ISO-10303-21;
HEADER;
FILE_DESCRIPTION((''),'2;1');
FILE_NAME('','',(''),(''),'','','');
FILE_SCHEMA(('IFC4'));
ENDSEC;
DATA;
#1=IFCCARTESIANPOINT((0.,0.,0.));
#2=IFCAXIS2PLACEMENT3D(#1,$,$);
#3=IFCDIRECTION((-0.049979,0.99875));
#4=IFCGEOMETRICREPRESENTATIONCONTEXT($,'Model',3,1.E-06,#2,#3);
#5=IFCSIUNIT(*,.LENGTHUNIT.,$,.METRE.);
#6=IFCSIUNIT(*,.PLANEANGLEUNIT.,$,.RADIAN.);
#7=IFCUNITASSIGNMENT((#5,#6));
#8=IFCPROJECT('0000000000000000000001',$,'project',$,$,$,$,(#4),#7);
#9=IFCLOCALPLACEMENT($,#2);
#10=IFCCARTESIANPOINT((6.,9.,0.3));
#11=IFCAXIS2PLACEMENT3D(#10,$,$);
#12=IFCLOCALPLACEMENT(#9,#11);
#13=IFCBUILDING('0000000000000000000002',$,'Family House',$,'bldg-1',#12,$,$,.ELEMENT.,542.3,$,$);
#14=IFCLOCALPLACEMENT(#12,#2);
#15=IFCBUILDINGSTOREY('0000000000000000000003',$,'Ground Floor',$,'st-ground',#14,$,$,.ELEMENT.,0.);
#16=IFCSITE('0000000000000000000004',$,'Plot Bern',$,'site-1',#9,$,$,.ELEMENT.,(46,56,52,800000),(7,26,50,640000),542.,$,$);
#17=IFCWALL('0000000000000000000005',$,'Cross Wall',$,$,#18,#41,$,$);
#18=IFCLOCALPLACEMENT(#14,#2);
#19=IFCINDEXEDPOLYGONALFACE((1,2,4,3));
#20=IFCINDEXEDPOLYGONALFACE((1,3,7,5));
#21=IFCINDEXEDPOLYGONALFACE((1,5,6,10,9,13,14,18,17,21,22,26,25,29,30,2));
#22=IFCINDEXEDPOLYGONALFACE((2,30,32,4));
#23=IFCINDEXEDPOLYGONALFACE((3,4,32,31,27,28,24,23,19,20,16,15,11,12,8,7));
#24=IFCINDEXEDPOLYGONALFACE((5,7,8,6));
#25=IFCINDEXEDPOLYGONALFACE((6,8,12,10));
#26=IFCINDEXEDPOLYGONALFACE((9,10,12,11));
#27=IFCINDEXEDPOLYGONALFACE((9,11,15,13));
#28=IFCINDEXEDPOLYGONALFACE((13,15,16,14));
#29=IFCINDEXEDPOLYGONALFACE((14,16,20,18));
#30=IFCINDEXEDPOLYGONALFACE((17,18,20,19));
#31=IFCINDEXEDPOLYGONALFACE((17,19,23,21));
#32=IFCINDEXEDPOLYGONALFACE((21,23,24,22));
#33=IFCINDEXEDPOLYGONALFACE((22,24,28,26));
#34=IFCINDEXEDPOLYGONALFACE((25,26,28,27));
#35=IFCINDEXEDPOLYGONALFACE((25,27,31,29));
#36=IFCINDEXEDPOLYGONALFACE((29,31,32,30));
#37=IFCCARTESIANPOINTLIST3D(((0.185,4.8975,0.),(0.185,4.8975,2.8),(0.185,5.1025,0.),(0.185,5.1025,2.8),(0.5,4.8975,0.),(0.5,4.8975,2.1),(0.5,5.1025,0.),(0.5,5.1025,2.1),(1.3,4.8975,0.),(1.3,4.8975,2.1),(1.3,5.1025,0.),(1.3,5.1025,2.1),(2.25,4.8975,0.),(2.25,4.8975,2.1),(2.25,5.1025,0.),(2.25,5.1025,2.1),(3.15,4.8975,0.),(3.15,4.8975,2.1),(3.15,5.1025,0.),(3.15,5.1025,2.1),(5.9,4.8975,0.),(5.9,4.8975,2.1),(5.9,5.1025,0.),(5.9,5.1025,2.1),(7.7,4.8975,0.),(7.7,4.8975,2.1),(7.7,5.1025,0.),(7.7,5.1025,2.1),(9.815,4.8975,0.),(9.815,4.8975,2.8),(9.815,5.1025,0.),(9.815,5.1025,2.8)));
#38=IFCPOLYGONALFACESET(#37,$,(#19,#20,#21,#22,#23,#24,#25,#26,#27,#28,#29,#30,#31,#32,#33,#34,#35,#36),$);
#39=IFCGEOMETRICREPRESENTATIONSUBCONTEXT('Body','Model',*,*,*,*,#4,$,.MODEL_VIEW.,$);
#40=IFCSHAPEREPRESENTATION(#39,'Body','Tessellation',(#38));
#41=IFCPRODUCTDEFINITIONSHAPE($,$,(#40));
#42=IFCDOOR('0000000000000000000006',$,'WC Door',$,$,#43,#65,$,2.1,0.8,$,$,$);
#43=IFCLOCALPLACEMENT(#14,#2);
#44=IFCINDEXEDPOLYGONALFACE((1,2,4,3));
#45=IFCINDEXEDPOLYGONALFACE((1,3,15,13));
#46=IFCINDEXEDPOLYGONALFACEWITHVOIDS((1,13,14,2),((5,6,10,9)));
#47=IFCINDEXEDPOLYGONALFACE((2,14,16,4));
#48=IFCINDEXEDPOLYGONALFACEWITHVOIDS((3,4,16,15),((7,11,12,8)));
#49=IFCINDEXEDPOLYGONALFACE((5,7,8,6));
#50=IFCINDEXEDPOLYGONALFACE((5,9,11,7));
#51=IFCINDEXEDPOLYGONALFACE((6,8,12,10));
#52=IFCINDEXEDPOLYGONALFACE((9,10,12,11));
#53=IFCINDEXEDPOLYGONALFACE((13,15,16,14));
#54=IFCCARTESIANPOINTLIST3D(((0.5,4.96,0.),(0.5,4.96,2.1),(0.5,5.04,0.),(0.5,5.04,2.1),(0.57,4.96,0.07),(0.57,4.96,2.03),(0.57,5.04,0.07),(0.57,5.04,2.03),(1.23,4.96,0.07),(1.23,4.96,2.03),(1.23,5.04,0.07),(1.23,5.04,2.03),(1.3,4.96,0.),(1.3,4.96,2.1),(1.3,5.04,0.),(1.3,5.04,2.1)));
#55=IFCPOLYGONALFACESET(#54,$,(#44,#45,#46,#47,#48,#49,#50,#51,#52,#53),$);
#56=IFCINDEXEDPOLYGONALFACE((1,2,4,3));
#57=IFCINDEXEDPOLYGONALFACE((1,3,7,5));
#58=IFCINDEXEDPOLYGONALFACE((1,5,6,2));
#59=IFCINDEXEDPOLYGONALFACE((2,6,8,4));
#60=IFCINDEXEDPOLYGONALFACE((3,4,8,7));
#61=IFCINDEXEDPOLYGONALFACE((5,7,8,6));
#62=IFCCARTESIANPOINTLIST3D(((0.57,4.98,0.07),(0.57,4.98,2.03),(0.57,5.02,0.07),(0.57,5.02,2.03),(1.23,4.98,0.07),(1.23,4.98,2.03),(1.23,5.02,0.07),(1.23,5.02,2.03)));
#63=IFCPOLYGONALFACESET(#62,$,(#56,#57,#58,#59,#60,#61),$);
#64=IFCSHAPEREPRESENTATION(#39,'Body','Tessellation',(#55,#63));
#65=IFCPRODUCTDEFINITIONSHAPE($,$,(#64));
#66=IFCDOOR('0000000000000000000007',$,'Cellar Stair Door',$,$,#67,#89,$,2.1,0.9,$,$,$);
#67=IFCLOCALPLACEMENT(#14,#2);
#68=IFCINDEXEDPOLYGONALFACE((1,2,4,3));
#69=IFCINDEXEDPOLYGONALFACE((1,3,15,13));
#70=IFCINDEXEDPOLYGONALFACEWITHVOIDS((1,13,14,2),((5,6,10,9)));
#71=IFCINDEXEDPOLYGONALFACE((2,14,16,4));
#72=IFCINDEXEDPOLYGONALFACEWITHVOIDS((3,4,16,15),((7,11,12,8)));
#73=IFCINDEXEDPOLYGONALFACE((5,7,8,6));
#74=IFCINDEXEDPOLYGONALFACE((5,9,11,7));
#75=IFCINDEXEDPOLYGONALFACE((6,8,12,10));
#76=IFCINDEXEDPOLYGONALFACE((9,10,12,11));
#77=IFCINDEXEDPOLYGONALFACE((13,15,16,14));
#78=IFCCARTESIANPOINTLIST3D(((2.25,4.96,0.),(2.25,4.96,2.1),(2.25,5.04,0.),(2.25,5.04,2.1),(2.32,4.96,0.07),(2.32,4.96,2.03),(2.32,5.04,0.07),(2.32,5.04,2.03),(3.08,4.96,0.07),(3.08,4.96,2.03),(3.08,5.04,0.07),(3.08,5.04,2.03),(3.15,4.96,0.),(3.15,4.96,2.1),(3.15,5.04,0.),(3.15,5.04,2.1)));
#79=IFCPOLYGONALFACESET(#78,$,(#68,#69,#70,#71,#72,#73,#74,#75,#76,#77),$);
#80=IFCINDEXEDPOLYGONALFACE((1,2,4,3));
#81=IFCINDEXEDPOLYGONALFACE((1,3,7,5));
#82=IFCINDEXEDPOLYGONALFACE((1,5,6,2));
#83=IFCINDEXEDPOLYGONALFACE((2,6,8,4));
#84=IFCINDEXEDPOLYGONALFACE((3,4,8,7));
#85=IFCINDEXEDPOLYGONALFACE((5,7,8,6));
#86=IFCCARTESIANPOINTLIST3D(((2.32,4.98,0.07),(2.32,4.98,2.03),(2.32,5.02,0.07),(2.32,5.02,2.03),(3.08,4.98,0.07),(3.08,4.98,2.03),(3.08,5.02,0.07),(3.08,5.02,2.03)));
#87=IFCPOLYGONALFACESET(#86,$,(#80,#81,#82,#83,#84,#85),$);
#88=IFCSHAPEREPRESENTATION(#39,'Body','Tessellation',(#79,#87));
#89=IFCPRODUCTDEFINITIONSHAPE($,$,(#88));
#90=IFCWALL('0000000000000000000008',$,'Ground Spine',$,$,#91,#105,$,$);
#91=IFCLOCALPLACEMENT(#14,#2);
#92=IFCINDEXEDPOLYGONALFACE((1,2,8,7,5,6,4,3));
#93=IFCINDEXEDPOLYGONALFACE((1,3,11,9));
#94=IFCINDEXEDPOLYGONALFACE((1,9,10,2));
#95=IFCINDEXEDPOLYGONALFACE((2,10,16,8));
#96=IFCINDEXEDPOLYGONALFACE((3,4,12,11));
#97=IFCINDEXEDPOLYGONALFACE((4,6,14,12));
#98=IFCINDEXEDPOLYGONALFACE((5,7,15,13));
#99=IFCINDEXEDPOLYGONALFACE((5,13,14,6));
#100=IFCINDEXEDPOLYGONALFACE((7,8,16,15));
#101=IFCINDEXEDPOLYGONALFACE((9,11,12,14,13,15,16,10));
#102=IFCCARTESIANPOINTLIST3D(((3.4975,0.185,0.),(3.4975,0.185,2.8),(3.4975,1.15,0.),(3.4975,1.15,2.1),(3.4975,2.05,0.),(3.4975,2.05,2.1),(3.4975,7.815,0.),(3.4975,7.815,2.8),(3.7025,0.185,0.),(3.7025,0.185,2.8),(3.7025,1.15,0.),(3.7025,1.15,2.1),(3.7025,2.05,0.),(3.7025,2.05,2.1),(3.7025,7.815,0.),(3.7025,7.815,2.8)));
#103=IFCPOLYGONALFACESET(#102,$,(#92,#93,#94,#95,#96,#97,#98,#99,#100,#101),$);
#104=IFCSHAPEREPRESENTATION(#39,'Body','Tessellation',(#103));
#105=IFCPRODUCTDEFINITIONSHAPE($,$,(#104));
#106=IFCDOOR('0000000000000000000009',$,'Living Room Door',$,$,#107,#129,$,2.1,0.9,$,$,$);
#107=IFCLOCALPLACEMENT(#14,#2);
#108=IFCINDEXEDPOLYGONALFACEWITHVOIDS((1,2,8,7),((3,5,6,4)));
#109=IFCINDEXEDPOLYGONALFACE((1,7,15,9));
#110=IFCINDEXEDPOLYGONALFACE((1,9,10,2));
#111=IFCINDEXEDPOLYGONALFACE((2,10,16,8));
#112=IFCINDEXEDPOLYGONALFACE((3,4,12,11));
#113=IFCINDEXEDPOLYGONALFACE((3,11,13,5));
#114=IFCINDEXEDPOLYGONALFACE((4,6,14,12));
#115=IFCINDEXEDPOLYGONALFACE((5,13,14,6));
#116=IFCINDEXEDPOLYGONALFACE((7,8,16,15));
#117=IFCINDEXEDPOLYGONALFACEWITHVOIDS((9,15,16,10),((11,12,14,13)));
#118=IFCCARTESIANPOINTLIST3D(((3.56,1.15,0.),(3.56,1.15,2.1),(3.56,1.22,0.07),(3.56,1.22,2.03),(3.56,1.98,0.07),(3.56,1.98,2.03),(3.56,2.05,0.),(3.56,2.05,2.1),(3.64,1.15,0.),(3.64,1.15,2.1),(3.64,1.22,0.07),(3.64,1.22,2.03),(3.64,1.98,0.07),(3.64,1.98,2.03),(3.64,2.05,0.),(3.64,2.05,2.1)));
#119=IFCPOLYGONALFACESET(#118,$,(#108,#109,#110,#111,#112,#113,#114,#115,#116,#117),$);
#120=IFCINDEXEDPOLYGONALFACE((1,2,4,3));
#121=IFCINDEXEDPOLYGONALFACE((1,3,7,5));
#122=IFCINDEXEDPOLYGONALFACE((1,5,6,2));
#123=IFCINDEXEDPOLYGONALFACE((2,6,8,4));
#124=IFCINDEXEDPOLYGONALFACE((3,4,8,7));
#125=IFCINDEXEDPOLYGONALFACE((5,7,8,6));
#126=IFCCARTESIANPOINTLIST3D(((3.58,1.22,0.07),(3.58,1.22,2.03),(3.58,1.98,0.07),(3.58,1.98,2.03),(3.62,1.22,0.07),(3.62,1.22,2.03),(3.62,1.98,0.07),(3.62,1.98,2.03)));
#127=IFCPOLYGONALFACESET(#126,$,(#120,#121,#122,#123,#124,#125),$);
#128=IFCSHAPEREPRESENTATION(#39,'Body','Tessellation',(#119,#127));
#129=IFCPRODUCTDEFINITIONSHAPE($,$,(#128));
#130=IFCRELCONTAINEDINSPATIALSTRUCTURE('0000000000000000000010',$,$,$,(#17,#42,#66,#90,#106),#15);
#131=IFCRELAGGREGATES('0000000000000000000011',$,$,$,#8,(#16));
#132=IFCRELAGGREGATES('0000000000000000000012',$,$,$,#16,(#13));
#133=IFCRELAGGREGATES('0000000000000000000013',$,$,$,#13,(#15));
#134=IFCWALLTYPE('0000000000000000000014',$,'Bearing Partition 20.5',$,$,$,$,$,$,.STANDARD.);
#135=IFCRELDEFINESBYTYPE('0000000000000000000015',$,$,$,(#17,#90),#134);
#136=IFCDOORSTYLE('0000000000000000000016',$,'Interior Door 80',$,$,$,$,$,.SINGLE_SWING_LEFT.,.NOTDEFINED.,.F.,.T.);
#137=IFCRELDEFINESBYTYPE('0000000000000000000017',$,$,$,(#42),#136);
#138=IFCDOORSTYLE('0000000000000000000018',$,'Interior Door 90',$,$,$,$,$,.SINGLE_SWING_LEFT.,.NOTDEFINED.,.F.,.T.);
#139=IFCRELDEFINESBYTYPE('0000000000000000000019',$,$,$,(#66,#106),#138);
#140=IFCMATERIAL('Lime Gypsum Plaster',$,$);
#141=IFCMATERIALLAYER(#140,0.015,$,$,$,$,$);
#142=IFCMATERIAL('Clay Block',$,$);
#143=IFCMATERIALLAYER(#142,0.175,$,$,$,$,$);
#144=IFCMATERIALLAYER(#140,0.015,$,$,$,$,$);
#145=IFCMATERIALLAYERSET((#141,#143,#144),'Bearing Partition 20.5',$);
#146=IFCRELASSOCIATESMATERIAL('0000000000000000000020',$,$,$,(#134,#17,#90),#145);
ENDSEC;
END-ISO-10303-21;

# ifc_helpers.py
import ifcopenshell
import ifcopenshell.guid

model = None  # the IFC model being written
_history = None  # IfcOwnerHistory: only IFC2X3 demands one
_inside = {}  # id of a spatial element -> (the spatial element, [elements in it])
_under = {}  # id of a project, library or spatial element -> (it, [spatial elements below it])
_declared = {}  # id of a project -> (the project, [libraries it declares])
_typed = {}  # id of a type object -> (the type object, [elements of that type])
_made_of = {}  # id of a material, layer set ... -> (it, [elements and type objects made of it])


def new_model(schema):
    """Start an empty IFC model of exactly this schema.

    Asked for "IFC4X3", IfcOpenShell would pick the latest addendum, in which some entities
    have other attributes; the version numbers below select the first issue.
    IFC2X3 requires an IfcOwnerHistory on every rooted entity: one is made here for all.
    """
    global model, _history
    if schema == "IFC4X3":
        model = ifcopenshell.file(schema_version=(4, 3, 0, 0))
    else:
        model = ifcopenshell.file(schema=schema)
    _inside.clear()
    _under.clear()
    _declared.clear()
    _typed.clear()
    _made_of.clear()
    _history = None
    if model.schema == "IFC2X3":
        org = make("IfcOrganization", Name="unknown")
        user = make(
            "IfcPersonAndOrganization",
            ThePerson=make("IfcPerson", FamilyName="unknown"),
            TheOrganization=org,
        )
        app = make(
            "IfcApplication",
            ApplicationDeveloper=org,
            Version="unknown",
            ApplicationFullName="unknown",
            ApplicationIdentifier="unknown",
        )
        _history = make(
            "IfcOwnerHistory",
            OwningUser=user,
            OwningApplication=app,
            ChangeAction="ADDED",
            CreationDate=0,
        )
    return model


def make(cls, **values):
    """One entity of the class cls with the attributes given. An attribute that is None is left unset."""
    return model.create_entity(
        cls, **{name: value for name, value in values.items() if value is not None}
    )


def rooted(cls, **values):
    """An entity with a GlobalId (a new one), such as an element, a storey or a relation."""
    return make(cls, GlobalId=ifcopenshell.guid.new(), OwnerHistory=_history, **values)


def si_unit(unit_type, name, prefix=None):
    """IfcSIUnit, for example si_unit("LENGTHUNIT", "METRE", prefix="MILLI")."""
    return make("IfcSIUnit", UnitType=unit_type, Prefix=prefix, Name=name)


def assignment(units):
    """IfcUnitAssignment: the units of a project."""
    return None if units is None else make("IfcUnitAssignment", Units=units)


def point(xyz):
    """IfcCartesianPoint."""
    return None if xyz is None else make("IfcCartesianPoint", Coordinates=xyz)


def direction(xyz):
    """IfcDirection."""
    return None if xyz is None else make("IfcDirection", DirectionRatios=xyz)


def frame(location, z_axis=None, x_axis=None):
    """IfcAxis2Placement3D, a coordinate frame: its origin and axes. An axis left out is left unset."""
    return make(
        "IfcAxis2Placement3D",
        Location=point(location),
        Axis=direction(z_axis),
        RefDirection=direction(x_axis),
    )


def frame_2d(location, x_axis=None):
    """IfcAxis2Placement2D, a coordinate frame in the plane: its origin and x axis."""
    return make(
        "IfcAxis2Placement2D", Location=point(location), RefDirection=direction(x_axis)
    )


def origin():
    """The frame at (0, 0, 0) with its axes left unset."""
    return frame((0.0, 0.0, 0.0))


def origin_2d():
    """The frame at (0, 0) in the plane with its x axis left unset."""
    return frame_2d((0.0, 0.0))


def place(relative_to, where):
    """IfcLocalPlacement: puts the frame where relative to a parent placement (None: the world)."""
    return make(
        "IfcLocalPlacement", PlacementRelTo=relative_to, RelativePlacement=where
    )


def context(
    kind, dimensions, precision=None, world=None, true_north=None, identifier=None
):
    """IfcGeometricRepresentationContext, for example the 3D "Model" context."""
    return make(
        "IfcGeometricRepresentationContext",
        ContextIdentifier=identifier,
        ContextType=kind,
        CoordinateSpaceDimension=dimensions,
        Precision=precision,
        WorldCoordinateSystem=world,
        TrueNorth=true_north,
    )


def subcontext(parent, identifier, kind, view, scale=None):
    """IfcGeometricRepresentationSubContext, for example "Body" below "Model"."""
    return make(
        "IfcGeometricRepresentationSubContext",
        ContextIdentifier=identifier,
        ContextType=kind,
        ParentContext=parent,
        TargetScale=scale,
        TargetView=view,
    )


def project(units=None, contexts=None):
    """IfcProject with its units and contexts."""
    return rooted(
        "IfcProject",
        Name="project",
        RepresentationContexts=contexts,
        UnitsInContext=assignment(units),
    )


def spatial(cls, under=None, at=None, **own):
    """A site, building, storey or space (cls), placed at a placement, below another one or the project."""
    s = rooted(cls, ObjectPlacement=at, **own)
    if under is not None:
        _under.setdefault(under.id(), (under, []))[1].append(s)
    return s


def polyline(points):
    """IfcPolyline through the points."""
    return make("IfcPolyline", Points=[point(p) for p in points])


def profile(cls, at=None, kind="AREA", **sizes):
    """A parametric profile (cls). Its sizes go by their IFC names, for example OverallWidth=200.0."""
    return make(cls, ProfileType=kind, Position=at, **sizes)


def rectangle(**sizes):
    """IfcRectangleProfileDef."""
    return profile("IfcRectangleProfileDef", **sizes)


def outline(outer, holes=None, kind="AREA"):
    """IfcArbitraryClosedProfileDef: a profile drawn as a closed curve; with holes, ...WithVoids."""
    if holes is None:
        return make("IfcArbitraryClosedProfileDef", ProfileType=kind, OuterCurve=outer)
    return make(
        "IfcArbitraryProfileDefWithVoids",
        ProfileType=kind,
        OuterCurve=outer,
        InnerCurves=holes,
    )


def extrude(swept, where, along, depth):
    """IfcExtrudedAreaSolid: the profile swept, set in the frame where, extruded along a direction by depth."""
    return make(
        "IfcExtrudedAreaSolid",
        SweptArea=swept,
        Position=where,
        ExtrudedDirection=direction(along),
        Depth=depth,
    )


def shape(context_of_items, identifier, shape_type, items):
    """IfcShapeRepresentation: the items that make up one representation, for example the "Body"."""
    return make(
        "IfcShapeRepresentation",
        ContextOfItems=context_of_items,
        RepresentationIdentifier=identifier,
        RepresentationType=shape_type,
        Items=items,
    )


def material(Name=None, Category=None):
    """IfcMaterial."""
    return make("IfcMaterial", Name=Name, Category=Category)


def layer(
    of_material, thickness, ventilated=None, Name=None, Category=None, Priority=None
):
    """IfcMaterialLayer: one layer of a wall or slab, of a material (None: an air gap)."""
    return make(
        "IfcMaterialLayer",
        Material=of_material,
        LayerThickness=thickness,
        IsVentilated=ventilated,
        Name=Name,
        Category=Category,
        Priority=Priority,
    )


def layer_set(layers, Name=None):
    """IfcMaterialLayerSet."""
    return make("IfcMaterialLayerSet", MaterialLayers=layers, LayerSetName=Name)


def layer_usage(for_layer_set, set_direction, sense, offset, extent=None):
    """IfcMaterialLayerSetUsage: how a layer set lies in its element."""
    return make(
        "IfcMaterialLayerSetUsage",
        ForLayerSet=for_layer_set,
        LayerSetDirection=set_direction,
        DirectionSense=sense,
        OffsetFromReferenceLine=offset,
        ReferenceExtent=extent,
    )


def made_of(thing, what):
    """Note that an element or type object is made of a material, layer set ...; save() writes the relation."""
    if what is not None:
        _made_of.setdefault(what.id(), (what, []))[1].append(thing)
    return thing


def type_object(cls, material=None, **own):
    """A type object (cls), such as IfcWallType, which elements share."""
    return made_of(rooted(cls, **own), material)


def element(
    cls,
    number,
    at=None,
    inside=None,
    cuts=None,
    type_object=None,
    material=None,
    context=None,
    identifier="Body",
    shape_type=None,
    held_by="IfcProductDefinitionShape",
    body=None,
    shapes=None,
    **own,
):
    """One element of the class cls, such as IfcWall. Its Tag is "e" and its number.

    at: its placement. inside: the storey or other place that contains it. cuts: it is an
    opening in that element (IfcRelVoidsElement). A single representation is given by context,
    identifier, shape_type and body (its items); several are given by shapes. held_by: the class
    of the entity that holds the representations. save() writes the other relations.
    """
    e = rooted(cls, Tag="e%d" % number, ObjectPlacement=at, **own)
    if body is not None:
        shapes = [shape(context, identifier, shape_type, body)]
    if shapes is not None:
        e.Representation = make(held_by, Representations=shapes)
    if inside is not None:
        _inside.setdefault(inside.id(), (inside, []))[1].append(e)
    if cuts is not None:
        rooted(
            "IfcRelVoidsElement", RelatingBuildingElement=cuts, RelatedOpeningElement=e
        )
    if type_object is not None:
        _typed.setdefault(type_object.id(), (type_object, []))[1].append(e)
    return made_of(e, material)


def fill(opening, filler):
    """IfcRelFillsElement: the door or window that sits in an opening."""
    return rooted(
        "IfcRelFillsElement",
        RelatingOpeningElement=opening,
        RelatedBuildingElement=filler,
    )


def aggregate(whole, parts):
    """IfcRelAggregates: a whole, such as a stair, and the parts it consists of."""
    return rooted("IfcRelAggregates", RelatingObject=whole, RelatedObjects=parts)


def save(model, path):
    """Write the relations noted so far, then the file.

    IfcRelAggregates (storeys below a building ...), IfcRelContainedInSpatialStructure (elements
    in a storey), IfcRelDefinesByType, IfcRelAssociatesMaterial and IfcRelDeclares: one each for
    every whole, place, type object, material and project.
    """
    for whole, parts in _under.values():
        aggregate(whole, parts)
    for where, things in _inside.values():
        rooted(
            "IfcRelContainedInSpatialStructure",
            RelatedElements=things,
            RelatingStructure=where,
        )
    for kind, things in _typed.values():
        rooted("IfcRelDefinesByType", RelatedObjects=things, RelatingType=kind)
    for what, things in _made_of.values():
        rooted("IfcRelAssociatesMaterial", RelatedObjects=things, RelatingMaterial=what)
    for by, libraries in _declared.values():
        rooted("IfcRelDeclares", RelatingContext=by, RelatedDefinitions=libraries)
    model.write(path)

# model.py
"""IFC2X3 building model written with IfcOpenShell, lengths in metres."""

from ifc_helpers import new_model, si_unit, direction, frame, frame_2d, origin, origin_2d, place, context, subcontext, project, spatial, polyline, rectangle, outline, extrude, material, layer, layer_set, layer_usage, type_object, element, fill, save


model = new_model("IFC2X3")

# Units and contexts
model_context = context("Model", 3, precision=1e-06, world=origin(), true_north=direction((-0.049979, 0.99875)))
body_context = subcontext(model_context, "Body", "Model", "MODEL_VIEW")
ifc_project = project(units=[si_unit("LENGTHUNIT", "METRE"), si_unit("PLANEANGLEUNIT", "RADIAN")], contexts=[model_context])

# Site, building, storey
site_placement = place(None, origin())
site = spatial("IfcSite", under=ifc_project, at=site_placement, Name="Plot Bern", ObjectType="site-1", CompositionType="ELEMENT", RefLatitude=(46, 56, 52, 800000), RefLongitude=(7, 26, 50, 640000), RefElevation=542.0)
building_placement = place(site_placement, frame((6.0, 9.0, 0.3)))
building = spatial("IfcBuilding", under=site, at=building_placement, Name="Family House", ObjectType="bldg-1", CompositionType="ELEMENT", ElevationOfRefHeight=542.3)
storey_placement = place(building_placement, origin())
storey = spatial("IfcBuildingStorey", under=building, at=storey_placement, Name="Ground Floor", ObjectType="st-ground", CompositionType="ELEMENT", Elevation=0.0)

# Shared definitions
ifc_material_1 = material(Name="Lime Gypsum Plaster")
ifc_material_2 = material(Name="Clay Block")

# Wall, openings, doors
ifc_layer_1 = layer(ifc_material_1, 0.015)
ifc_layer_2 = layer(ifc_material_2, 0.175)
ifc_layer_3 = layer(ifc_material_1, 0.015)
ifc_layer_set_1 = layer_set([ifc_layer_1, ifc_layer_2, ifc_layer_3], Name="Bearing Partition 20.5")
ifc_layer_usage_1 = layer_usage(ifc_layer_set_1, "AXIS2", "NEGATIVE", 0.1025)
wall_type_1 = type_object("IfcWallType", Name="Bearing Partition 20.5", PredefinedType="STANDARD", material=ifc_layer_set_1)
wall_1_placement = place(storey_placement, origin())
wall_1 = element("IfcWall", 1, at=wall_1_placement, inside=storey, type_object=wall_type_1, material=ifc_layer_usage_1, Name="Cross Wall", context=body_context, shape_type="SweptSolid", body=[
    extrude(outline(polyline([(0.185, 4.8975), (9.815, 4.8975), (9.815, 5.1025), (0.185, 5.1025), (0.185, 4.8975)])), origin(), (0.0, 0.0, 1.0), 2.8),
])
opening_1_placement = place(wall_1_placement, frame((2.7, 5.0, 0.0), z_axis=(0.0, 0.0, 1.0), x_axis=(1.0, 0.0, 0.0)))
opening_1 = element("IfcOpeningElement", 2, at=opening_1_placement, cuts=wall_1, context=body_context, shape_type="SweptSolid", body=[
    extrude(rectangle(XDim=0.9, YDim=0.205, at=origin_2d()), origin(), (0.0, 0.0, 1.0), 2.1),
])
opening_2_placement = place(wall_1_placement, frame((6.8, 5.0, 0.0), z_axis=(0.0, 0.0, 1.0), x_axis=(1.0, 0.0, 0.0)))
element("IfcOpeningElement", 3, at=opening_2_placement, cuts=wall_1, context=body_context, shape_type="SweptSolid", body=[
    extrude(rectangle(XDim=1.8, YDim=0.205, at=origin_2d()), origin(), (0.0, 0.0, 1.0), 2.1),
])
opening_3_placement = place(wall_1_placement, frame((0.9, 5.0, 0.0), z_axis=(0.0, 0.0, 1.0), x_axis=(1.0, 0.0, 0.0)))
opening_3 = element("IfcOpeningElement", 4, at=opening_3_placement, cuts=wall_1, context=body_context, shape_type="SweptSolid", body=[
    extrude(rectangle(XDim=0.8, YDim=0.205, at=origin_2d()), origin(), (0.0, 0.0, 1.0), 2.1),
])
door_style_1 = type_object("IfcDoorStyle", Name="Interior Door 80", ConstructionType="NOTDEFINED", OperationType="SINGLE_SWING_LEFT", ParameterTakesPrecedence=False, Sizeable=True)
door_1_placement = place(opening_3_placement, frame((0.0, 0.0, 0.0), z_axis=(0.0, -1.0, 0.0), x_axis=(1.0, 0.0, 0.0)))
door_1 = element("IfcDoor", 5, at=door_1_placement, inside=storey, type_object=door_style_1, Name="WC Door", OverallHeight=2.1, OverallWidth=0.8, context=body_context, shape_type="SweptSolid", body=[
    extrude(outline(polyline([(-0.4, 0.0), (0.4, 0.0), (0.4, 2.1), (-0.4, 2.1), (-0.4, 0.0)]), holes=[polyline([(-0.33, 0.07), (0.33, 0.07), (0.33, 2.03), (-0.33, 2.03), (-0.33, 0.07)])]), frame((0.0, 0.0, -0.04)), (0.0, 0.0, 1.0), 0.08),
    extrude(rectangle(XDim=0.66, YDim=1.96, at=frame_2d((0.0, 1.05))), frame((0.0, 0.0, -0.02)), (0.0, 0.0, 1.0), 0.04),
])
fill(opening_3, door_1)
door_style_2 = type_object("IfcDoorStyle", Name="Interior Door 90", ConstructionType="NOTDEFINED", OperationType="SINGLE_SWING_LEFT", ParameterTakesPrecedence=False, Sizeable=True)
door_2_placement = place(opening_1_placement, frame((0.0, 0.0, 0.0), z_axis=(0.0, 1.0, 0.0), x_axis=(-1.0, 0.0, 0.0)))
door_2 = element("IfcDoor", 6, at=door_2_placement, inside=storey, type_object=door_style_2, Name="Cellar Stair Door", OverallHeight=2.1, OverallWidth=0.9, context=body_context, shape_type="SweptSolid", body=[
    extrude(outline(polyline([(-0.45, 0.0), (0.45, 0.0), (0.45, 2.1), (-0.45, 2.1), (-0.45, 0.0)]), holes=[polyline([(-0.38, 0.07), (0.38, 0.07), (0.38, 2.03), (-0.38, 2.03), (-0.38, 0.07)])]), frame((0.0, 0.0, -0.04)), (0.0, 0.0, 1.0), 0.08),
    extrude(rectangle(XDim=0.76, YDim=1.96, at=frame_2d((0.0, 1.05))), frame((0.0, 0.0, -0.02)), (0.0, 0.0, 1.0), 0.04),
])
fill(opening_1, door_2)

# Wall, opening, door
ifc_layer_usage_2 = layer_usage(ifc_layer_set_1, "AXIS2", "NEGATIVE", 0.1025)
wall_2_placement = place(storey_placement, origin())
wall_2 = element("IfcWall", 7, at=wall_2_placement, inside=storey, type_object=wall_type_1, material=ifc_layer_usage_2, Name="Ground Spine", context=body_context, shape_type="SweptSolid", body=[
    extrude(outline(polyline([(3.7025, 0.185), (3.7025, 7.815), (3.4975, 7.815), (3.4975, 0.185), (3.7025, 0.185)])), origin(), (0.0, 0.0, 1.0), 2.8),
])
opening_4_placement = place(wall_2_placement, frame((3.6, 1.6, 0.0), z_axis=(0.0, 0.0, 1.0), x_axis=(0.0, 1.0, 0.0)))
opening_4 = element("IfcOpeningElement", 8, at=opening_4_placement, cuts=wall_2, context=body_context, shape_type="SweptSolid", body=[
    extrude(rectangle(XDim=0.9, YDim=0.205, at=origin_2d()), origin(), (0.0, 0.0, 1.0), 2.1),
])
door_3_placement = place(opening_4_placement, frame((0.0, 0.0, 0.0), z_axis=(0.0, -1.0, 0.0), x_axis=(1.0, 0.0, 0.0)))
door_3 = element("IfcDoor", 9, at=door_3_placement, inside=storey, type_object=door_style_2, Name="Living Room Door", OverallHeight=2.1, OverallWidth=0.9, context=body_context, shape_type="SweptSolid", body=[
    extrude(outline(polyline([(-0.45, 0.0), (0.45, 0.0), (0.45, 2.1), (-0.45, 2.1), (-0.45, 0.0)]), holes=[polyline([(-0.38, 0.07), (0.38, 0.07), (0.38, 2.03), (-0.38, 2.03), (-0.38, 0.07)])]), frame((0.0, 0.0, -0.04)), (0.0, 0.0, 1.0), 0.08),
    extrude(rectangle(XDim=0.76, YDim=1.96, at=frame_2d((0.0, 1.05))), frame((0.0, 0.0, -0.02)), (0.0, 0.0, 1.0), 0.04),
])
fill(opening_4, door_3)

save(model, "model.ifc")
